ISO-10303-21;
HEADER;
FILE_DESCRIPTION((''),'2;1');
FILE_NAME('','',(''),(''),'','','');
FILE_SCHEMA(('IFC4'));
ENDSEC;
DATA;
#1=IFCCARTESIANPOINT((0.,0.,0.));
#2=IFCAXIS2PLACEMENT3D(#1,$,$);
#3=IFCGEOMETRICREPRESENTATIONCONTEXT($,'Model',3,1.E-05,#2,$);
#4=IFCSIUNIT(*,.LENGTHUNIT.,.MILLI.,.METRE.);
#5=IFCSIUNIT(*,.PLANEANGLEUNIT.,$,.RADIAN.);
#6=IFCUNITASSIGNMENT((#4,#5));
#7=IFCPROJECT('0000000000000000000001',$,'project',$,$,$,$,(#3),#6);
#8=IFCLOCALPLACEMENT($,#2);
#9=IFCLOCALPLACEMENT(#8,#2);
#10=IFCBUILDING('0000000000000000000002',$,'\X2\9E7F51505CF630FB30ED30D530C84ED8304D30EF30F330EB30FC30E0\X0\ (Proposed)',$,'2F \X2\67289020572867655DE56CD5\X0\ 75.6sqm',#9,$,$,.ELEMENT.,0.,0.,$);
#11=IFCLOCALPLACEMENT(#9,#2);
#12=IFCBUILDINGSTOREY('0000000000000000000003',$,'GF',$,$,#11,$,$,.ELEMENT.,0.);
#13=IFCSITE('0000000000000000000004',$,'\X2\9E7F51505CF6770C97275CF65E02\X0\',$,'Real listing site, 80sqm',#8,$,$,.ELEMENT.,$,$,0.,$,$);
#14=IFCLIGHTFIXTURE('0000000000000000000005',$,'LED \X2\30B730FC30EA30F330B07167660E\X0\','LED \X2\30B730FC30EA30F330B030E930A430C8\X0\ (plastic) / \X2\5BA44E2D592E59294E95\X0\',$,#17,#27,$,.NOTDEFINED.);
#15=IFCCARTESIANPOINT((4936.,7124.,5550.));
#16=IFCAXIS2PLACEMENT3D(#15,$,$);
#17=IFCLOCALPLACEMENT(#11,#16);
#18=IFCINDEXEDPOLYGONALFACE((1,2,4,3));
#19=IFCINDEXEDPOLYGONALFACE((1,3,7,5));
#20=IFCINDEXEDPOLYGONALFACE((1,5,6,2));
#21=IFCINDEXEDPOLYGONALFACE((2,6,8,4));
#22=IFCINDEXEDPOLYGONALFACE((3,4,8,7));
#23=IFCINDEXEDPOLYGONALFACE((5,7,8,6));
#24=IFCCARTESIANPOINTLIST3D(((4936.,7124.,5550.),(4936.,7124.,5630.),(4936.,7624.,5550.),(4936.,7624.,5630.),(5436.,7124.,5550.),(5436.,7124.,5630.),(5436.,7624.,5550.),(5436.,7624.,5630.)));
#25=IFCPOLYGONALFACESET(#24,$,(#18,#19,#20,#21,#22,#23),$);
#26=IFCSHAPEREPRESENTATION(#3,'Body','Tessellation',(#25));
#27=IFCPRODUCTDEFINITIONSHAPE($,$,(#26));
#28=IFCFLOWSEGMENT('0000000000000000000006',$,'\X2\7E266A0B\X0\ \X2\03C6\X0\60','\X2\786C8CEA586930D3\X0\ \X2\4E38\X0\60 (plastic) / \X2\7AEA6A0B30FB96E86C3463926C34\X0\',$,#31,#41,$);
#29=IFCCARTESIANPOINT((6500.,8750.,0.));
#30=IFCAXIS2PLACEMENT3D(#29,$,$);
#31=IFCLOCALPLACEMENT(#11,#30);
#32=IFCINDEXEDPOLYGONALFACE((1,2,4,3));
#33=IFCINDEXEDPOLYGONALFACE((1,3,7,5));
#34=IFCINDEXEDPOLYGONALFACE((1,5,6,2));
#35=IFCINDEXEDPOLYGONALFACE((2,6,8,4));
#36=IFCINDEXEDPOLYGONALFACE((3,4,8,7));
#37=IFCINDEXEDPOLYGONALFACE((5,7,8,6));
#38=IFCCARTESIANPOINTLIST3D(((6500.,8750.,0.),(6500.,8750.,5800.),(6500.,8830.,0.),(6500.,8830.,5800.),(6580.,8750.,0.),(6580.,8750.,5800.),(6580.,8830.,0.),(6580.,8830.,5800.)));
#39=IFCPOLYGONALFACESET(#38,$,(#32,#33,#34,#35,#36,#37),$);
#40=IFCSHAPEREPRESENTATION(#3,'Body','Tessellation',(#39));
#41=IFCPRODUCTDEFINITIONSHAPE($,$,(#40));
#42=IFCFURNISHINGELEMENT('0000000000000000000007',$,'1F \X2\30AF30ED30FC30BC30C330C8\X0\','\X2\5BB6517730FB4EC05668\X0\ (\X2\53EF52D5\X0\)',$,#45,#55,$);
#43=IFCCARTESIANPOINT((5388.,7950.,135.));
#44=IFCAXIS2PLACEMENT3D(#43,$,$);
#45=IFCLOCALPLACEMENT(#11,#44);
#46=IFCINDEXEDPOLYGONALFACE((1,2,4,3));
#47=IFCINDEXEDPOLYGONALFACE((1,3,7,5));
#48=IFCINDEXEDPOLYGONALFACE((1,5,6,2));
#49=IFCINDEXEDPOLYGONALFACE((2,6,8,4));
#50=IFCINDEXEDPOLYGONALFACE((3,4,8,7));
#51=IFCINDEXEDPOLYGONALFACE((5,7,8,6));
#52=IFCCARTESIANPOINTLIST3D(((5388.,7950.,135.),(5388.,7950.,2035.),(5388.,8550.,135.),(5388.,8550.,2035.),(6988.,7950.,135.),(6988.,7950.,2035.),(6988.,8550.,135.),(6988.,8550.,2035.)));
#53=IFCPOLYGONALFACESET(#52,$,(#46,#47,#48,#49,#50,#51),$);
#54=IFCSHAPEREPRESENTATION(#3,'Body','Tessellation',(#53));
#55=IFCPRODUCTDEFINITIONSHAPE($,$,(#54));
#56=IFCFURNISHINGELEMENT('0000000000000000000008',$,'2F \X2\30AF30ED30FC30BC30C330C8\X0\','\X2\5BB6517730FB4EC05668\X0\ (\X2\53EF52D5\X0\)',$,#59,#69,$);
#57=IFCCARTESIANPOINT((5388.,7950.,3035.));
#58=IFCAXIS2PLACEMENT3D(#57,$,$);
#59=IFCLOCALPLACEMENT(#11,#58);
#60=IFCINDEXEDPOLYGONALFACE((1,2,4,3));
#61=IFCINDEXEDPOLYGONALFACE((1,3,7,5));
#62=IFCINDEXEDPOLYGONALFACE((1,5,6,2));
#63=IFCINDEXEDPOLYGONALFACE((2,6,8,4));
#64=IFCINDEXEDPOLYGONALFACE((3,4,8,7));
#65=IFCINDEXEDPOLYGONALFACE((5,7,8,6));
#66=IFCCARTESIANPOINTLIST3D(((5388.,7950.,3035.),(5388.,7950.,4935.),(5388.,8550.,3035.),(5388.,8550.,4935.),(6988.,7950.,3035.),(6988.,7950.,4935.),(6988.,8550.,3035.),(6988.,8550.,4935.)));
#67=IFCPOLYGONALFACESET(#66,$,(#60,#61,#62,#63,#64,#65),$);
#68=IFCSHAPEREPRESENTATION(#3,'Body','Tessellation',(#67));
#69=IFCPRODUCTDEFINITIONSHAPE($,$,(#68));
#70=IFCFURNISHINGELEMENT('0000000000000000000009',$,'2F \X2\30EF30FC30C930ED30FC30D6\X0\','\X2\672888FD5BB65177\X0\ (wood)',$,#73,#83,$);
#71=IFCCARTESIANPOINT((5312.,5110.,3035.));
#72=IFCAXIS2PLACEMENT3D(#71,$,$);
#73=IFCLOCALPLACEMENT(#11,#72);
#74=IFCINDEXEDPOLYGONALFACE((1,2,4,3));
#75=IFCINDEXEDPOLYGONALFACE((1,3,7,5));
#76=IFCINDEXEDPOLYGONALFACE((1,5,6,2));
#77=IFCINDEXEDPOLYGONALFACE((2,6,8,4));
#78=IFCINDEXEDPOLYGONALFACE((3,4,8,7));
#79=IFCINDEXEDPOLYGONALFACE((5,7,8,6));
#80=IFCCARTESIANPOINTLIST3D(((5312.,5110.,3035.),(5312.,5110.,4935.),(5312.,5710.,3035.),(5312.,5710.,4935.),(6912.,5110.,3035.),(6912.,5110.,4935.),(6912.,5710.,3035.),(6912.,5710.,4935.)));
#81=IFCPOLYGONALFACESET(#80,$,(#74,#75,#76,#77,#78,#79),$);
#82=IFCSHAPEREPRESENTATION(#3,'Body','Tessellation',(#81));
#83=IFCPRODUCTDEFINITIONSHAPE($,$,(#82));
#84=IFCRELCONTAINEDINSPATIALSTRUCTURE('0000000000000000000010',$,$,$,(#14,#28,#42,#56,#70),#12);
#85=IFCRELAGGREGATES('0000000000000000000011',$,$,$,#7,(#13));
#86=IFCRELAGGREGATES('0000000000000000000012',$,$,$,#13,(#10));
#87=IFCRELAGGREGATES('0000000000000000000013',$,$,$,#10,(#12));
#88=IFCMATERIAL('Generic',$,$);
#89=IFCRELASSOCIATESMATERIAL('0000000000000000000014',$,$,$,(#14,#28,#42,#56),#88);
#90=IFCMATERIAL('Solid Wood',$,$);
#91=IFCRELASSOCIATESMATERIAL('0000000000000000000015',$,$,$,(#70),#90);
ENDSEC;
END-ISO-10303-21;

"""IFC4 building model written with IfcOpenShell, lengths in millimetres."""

from ifc_helpers import new_model, si_unit, frame, frame_2d, origin, place, context, project, spatial, rectangle, extrude, material, element, save


model = new_model("IFC4")

# Units and contexts
model_context = context("Model", 3, precision=1e-05, world=origin())
ifc_project = project(units=[si_unit("LENGTHUNIT", "METRE", prefix="MILLI"), si_unit("PLANEANGLEUNIT", "RADIAN")], contexts=[model_context])

# Site, building, storey
site_placement = place(None, origin())
site = spatial("IfcSite", under=ifc_project, at=site_placement, Name="鹿児島県霧島市", ObjectType="Real listing site, 80sqm", CompositionType="ELEMENT", RefElevation=0.0)
building_placement = place(site_placement, origin())
building = spatial("IfcBuilding", under=site, at=building_placement, Name="鹿児島・ロフト付きワンルーム (Proposed)", ObjectType="2F 木造在来工法 75.6sqm", CompositionType="ELEMENT", ElevationOfRefHeight=0.0, ElevationOfTerrain=0.0)
storey_placement = place(building_placement, origin())
storey = spatial("IfcBuildingStorey", under=building, at=storey_placement, Name="GF", CompositionType="ELEMENT", Elevation=0.0)

# Shared definitions
ifc_material_1 = material(Name="Solid Wood")

# Shared definitions
ifc_material_2 = material(Name="Generic")

# Light fixture
light_fixture_1_placement = place(storey_placement, frame((4936.0, 7124.0, 5550.0)))
element("IfcLightFixture", 1, at=light_fixture_1_placement, inside=storey, material=ifc_material_2, Name="LED シーリング照明", Description="LED シーリングライト (plastic) / 室中央天井", PredefinedType="NOTDEFINED", context=model_context, shape_type="SweptSolid", body=[
    extrude(rectangle(XDim=500.0, YDim=500.0, at=frame_2d((250.0, 250.0))), frame((4936.0, 7124.0, 5550.0)), (0.0, 0.0, 1.0), 80.0),
])

# Flow segment
flow_segment_placement = place(storey_placement, frame((6500.0, 8750.0, 0.0)))
element("IfcFlowSegment", 2, at=flow_segment_placement, inside=storey, material=ifc_material_2, Name="縦樋 φ60", Description="硬質塩ビ 丸60 (plastic) / 竪樋・雨水排水", context=model_context, shape_type="SweptSolid", body=[
    extrude(rectangle(XDim=80.0, YDim=80.0, at=frame_2d((40.0, 40.0))), frame((6500.0, 8750.0, 0.0)), (0.0, 0.0, 1.0), 5800.0),
])

# Furnishing elements
furnishing_1_placement = place(storey_placement, frame((5388.0, 7950.0, 135.0)))
element("IfcFurnishingElement", 3, at=furnishing_1_placement, inside=storey, material=ifc_material_2, Name="1F クローゼット", Description="家具・什器 (可動)", context=model_context, shape_type="SweptSolid", body=[
    extrude(rectangle(XDim=1600.0, YDim=600.0, at=frame_2d((800.0, 300.0))), frame((5388.0, 7950.0, 135.0)), (0.0, 0.0, 1.0), 1900.0),
])
furnishing_2_placement = place(storey_placement, frame((5388.0, 7950.0, 3035.0)))
element("IfcFurnishingElement", 4, at=furnishing_2_placement, inside=storey, material=ifc_material_2, Name="2F クローゼット", Description="家具・什器 (可動)", context=model_context, shape_type="SweptSolid", body=[
    extrude(rectangle(XDim=1600.0, YDim=600.0, at=frame_2d((800.0, 300.0))), frame((5388.0, 7950.0, 3035.0)), (0.0, 0.0, 1.0), 1900.0),
])
furnishing_3_placement = place(storey_placement, frame((5312.0, 5110.0, 3035.0)))
element("IfcFurnishingElement", 5, at=furnishing_3_placement, inside=storey, material=ifc_material_1, Name="2F ワードローブ", Description="木製家具 (wood)", context=model_context, shape_type="SweptSolid", body=[
    extrude(rectangle(XDim=1600.0, YDim=600.0, at=frame_2d((800.0, 300.0))), frame((5312.0, 5110.0, 3035.0)), (0.0, 0.0, 1.0), 1900.0),
])

save(model, "model.ifc")
